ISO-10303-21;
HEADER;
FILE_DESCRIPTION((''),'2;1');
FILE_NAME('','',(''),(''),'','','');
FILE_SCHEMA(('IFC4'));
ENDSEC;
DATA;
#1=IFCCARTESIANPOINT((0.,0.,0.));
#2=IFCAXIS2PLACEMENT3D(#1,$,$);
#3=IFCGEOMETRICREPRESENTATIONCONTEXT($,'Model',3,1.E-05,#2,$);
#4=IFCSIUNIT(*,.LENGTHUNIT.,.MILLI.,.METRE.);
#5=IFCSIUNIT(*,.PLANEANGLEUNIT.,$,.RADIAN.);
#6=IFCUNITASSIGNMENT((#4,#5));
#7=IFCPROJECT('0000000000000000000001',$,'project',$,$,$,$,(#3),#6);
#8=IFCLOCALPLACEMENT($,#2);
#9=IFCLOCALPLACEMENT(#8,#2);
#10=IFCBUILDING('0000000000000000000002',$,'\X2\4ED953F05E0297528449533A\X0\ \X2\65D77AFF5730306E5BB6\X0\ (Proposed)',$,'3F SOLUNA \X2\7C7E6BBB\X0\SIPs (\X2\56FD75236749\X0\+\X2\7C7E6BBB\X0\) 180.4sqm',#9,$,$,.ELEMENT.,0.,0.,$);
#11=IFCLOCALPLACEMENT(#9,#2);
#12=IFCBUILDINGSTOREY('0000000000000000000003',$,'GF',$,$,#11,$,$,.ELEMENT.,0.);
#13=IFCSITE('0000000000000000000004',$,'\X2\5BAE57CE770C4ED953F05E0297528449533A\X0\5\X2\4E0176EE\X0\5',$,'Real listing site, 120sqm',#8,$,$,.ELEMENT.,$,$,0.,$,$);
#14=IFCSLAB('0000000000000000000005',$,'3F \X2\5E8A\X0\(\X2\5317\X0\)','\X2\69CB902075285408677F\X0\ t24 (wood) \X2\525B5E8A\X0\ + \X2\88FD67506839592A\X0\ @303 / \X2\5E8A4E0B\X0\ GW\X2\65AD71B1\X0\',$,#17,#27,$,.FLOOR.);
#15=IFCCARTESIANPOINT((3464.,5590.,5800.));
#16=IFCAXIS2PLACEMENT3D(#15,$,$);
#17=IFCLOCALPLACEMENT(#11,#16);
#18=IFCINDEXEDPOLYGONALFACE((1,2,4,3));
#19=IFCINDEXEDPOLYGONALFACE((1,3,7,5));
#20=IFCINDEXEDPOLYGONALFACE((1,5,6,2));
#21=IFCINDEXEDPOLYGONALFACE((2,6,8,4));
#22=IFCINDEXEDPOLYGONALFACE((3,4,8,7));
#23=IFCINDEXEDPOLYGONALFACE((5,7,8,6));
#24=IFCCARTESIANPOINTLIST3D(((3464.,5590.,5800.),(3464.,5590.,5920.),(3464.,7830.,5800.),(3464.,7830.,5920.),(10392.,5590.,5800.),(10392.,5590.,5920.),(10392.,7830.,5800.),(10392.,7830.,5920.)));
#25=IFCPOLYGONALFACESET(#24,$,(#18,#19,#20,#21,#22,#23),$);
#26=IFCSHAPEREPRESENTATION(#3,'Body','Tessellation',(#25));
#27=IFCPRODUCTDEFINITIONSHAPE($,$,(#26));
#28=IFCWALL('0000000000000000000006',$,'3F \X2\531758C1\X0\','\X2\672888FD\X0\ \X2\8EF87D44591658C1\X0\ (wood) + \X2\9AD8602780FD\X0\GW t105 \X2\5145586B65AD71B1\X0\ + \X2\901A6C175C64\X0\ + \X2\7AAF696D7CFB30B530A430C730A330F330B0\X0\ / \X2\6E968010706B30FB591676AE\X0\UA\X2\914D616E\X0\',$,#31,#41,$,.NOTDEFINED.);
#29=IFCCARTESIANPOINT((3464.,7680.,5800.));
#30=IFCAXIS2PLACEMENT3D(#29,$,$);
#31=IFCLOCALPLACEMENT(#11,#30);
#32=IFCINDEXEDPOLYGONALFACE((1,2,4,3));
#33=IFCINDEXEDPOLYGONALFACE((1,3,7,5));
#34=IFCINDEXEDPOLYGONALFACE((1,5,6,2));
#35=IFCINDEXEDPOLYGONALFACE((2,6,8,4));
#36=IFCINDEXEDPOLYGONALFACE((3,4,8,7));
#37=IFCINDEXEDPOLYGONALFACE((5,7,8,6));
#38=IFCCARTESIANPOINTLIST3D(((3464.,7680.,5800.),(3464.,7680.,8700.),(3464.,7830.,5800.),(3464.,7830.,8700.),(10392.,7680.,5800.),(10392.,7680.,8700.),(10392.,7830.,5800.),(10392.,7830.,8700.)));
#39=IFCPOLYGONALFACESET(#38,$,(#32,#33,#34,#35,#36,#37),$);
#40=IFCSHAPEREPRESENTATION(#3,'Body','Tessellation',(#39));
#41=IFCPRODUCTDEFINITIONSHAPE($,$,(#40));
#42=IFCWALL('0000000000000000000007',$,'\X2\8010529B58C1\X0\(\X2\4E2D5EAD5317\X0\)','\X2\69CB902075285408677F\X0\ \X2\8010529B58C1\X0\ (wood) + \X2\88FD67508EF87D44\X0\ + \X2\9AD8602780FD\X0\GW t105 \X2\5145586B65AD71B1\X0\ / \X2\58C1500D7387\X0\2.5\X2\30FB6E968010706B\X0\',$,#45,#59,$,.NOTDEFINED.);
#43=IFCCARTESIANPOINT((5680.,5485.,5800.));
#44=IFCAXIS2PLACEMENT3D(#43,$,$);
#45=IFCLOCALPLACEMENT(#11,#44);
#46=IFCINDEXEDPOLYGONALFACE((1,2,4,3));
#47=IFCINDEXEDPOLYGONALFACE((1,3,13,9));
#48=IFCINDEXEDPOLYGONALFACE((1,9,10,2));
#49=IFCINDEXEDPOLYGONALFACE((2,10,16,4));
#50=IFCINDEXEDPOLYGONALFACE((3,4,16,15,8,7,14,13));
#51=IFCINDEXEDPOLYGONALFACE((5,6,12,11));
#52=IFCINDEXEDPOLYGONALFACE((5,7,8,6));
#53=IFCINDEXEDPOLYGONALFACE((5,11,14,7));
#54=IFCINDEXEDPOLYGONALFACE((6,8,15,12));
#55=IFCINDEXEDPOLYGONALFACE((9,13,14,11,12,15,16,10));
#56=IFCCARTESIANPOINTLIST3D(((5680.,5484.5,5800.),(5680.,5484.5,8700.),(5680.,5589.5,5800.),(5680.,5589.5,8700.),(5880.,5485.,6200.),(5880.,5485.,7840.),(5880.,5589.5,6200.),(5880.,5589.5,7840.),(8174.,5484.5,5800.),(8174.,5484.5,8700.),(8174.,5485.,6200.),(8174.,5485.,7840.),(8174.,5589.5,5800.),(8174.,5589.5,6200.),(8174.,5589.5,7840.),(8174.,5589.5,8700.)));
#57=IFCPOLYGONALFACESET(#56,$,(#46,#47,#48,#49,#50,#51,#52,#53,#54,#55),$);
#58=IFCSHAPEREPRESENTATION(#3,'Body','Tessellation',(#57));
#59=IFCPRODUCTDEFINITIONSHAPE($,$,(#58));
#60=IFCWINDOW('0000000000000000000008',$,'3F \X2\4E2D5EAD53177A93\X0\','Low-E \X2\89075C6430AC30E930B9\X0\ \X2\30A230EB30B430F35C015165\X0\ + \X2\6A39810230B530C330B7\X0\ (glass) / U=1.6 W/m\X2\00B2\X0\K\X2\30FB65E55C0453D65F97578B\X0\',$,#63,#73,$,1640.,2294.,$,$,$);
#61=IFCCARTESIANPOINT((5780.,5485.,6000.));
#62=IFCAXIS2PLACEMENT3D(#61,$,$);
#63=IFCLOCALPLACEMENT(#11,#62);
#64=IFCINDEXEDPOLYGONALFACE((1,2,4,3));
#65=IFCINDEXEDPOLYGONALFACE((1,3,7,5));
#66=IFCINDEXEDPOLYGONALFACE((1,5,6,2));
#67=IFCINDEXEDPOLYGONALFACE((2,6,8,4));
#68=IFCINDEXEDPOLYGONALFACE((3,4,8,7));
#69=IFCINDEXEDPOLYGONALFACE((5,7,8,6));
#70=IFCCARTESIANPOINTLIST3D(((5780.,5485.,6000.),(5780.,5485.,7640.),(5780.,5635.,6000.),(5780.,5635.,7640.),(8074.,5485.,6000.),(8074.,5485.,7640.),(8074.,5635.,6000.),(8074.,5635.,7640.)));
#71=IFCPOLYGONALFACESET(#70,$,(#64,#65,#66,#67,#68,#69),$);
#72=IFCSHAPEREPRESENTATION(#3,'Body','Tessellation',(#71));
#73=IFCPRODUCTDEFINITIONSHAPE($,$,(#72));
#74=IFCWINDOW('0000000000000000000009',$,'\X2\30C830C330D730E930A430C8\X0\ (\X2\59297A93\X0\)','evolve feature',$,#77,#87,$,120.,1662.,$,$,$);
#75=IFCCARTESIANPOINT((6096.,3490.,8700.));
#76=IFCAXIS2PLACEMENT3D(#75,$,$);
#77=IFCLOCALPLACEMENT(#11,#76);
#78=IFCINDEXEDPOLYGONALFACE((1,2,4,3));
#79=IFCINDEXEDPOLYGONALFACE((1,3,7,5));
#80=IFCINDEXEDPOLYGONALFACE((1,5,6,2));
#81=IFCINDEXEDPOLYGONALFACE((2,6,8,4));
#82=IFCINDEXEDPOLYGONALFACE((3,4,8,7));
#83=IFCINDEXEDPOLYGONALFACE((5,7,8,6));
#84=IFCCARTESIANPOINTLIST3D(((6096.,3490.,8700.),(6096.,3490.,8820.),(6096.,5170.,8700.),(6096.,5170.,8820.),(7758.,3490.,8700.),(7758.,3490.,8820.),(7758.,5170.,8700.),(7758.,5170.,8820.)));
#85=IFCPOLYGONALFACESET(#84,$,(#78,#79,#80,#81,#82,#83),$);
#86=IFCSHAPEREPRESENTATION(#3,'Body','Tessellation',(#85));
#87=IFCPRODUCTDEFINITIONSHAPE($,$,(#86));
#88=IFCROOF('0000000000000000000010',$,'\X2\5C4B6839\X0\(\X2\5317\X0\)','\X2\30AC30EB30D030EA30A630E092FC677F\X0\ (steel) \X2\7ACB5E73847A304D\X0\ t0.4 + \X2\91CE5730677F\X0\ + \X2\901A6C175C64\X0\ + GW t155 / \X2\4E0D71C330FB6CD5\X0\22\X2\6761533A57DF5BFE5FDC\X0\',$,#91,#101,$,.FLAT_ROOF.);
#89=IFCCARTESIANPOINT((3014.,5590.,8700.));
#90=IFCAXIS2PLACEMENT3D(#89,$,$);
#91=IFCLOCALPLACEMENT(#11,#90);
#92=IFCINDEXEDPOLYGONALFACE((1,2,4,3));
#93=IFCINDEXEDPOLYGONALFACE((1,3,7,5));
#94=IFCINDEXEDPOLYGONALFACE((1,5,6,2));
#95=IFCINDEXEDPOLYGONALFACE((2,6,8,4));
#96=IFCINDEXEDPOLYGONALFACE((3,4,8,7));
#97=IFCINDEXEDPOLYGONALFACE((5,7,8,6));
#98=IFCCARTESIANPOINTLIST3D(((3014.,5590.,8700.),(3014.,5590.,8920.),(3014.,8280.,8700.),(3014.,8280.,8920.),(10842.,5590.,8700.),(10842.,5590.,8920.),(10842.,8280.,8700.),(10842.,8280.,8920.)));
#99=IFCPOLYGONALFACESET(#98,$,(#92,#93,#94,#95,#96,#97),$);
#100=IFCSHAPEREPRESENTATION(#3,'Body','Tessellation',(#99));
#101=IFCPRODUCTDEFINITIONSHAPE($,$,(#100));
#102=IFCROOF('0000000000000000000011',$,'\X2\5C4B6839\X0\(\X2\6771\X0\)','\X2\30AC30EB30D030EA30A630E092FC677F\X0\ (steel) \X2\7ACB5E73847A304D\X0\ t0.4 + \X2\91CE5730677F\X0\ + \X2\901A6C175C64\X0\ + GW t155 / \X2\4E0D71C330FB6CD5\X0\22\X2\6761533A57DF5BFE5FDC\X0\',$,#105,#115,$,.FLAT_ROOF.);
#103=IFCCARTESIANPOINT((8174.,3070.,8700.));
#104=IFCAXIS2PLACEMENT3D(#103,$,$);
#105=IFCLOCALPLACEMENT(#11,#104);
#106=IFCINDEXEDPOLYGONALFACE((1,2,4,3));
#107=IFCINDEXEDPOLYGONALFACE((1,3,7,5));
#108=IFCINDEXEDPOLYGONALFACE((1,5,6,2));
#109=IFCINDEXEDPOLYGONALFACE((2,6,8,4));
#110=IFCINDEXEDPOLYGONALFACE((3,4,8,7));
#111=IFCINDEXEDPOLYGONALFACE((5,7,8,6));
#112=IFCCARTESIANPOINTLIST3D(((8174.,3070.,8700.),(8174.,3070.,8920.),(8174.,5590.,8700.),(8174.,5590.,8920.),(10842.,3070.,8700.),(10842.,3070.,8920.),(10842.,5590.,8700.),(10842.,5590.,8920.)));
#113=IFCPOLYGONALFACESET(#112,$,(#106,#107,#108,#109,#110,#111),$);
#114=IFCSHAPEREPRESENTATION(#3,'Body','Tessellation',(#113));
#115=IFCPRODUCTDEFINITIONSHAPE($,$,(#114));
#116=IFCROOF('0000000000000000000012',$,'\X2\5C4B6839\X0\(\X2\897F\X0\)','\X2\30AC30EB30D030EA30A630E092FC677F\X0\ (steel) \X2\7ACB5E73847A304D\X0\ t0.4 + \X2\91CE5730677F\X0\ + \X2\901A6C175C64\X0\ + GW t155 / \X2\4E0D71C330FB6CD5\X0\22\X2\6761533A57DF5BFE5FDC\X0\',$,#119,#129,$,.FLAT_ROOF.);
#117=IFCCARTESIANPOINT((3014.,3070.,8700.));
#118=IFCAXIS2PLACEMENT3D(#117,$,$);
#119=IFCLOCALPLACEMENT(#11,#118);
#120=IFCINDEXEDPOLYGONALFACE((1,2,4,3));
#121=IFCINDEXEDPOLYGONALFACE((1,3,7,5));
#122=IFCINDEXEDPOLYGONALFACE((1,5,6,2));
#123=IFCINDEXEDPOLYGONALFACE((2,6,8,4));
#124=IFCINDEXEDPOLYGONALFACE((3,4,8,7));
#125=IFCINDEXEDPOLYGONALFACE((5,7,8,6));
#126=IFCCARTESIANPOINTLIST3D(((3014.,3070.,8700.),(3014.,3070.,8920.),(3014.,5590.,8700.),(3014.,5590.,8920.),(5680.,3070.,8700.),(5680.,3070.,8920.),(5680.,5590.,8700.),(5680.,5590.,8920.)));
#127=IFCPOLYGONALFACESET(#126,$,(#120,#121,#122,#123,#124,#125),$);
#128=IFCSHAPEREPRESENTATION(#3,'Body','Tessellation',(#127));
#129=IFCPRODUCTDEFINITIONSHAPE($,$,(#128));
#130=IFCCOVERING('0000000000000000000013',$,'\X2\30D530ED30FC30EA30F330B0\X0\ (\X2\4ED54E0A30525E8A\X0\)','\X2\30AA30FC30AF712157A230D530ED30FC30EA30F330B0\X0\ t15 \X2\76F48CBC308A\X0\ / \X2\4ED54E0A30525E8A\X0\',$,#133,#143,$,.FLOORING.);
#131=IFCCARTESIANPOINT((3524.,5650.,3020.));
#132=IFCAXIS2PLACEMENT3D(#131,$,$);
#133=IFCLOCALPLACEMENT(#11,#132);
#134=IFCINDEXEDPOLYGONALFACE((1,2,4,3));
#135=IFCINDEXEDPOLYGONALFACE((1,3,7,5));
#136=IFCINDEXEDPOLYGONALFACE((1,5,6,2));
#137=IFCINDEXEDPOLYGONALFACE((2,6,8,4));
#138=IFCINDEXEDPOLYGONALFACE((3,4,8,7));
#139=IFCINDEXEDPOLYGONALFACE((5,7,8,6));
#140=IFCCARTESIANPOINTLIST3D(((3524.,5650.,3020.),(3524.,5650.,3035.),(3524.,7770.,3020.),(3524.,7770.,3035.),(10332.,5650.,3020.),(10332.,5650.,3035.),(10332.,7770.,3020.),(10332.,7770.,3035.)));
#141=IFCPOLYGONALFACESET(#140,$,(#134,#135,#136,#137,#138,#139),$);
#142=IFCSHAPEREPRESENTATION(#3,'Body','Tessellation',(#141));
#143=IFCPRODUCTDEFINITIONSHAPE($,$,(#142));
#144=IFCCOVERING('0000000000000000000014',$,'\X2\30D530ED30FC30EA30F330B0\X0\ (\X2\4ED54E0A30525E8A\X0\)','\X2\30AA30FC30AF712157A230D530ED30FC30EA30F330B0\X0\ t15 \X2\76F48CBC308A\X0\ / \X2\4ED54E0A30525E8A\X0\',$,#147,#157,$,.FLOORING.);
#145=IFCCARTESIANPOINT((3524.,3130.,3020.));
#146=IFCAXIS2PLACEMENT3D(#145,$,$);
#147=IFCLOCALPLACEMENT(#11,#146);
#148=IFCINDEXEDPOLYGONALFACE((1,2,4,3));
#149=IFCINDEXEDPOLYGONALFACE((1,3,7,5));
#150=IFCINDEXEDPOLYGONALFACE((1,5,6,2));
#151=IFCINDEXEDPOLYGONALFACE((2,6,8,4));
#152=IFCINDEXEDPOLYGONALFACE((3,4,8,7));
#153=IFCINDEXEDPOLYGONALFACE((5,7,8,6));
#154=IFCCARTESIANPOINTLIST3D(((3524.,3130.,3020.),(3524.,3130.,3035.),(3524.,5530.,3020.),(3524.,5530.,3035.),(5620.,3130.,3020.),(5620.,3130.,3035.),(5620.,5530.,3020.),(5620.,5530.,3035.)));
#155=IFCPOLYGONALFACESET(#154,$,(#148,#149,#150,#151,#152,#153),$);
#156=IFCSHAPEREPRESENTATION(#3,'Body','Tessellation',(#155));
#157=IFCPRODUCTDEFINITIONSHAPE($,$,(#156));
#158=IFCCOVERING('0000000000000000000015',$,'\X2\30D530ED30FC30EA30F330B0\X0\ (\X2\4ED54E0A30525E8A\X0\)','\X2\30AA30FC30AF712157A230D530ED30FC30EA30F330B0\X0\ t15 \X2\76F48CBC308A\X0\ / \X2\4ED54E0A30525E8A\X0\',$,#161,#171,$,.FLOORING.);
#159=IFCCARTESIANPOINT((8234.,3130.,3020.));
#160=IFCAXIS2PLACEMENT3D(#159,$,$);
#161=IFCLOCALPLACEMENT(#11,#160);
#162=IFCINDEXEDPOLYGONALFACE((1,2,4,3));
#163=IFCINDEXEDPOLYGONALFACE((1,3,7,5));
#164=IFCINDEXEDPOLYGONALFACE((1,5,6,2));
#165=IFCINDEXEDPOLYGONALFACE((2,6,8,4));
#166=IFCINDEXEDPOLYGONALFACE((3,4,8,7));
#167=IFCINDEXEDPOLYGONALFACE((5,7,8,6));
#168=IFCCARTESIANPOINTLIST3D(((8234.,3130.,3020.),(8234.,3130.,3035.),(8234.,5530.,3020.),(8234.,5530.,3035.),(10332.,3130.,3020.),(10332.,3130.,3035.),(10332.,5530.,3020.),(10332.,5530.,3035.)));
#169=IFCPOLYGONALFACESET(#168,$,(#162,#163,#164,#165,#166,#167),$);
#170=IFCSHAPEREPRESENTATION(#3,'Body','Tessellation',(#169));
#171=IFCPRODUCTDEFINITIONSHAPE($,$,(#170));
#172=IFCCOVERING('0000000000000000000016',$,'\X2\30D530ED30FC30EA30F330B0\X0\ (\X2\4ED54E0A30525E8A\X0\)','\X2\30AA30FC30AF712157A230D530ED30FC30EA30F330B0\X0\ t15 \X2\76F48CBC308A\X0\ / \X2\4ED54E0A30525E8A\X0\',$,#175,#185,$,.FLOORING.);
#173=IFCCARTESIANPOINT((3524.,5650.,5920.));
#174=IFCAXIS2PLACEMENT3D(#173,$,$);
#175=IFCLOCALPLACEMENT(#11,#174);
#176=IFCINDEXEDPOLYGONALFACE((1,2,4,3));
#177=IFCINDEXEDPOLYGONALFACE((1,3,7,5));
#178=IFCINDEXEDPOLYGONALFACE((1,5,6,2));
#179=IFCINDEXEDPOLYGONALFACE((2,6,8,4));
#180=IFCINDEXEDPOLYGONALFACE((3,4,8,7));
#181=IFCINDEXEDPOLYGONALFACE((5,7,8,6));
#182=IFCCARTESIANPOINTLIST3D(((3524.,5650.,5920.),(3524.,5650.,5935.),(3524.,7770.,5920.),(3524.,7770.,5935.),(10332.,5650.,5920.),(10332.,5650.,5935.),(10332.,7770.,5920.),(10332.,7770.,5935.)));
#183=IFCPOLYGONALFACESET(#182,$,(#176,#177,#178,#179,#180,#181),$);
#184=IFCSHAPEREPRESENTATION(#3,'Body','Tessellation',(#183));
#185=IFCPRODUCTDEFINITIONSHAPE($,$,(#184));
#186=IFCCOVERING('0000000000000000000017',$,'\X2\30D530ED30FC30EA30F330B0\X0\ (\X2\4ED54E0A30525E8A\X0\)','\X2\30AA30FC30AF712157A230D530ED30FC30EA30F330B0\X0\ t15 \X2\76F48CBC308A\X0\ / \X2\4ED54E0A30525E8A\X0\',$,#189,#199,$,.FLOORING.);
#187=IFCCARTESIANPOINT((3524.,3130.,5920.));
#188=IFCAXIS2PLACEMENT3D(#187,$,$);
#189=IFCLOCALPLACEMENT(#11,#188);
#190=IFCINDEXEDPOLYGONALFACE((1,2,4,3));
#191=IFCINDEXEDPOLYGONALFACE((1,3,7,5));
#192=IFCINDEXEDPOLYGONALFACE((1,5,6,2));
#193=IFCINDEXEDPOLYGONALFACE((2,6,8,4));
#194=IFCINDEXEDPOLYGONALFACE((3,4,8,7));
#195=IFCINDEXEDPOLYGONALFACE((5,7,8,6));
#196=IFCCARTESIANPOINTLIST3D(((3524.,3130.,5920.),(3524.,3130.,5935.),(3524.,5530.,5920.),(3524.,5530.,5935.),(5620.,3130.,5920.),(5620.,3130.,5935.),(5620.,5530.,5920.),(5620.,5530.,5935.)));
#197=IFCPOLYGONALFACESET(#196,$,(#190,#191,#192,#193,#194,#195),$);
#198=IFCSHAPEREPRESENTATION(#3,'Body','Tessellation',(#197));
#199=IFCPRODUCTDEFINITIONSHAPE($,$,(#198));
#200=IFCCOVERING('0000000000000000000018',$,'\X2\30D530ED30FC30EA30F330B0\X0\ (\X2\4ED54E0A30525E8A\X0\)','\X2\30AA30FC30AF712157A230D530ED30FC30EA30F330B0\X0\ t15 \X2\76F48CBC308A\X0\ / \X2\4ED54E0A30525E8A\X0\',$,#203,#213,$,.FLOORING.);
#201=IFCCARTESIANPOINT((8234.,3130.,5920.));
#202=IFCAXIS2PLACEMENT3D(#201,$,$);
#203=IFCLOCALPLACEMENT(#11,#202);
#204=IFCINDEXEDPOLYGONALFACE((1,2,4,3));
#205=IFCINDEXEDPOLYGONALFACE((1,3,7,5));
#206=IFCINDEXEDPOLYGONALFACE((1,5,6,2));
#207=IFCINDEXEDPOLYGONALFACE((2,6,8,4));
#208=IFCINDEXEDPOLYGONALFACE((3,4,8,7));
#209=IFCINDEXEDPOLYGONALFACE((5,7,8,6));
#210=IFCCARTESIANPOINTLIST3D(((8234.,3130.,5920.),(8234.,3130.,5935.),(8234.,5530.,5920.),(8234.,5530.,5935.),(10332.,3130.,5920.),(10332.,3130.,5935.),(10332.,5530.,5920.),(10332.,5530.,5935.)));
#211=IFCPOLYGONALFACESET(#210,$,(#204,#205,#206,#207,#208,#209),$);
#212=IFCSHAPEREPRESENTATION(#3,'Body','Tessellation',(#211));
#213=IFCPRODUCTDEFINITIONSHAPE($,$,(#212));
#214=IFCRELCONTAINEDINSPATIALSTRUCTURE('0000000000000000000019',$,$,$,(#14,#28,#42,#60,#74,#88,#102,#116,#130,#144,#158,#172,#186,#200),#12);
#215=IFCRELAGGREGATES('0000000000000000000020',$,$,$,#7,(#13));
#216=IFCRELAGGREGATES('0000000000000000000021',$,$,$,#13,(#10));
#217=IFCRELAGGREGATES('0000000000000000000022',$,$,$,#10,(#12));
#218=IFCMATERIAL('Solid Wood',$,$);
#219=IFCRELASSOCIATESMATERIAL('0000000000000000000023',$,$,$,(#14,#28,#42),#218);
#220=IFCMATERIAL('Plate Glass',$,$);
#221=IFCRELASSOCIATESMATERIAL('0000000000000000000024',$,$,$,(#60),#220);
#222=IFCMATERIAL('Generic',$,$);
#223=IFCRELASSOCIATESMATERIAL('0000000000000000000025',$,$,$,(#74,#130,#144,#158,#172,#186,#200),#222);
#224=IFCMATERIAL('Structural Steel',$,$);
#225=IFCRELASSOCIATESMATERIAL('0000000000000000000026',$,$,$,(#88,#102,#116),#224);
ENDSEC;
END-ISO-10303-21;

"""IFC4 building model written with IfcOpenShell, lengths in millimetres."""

from ifc_helpers import new_model, si_unit, frame, frame_2d, origin, place, context, project, spatial, rectangle, extrude, material, element, fill, save


model = new_model("IFC4")

# Units and contexts
model_context = context("Model", 3, precision=1e-05, world=origin())
ifc_project = project(units=[si_unit("LENGTHUNIT", "METRE", prefix="MILLI"), si_unit("PLANEANGLEUNIT", "RADIAN")], contexts=[model_context])

# Site, building, storey
site_placement = place(None, origin())
site = spatial("IfcSite", under=ifc_project, at=site_placement, Name="宮城県仙台市青葉区5丁目5", ObjectType="Real listing site, 120sqm", CompositionType="ELEMENT", RefElevation=0.0)
building_placement = place(site_placement, origin())
building = spatial("IfcBuilding", under=site, at=building_placement, Name="仙台市青葉区 旗竿地の家 (Proposed)", ObjectType="3F SOLUNA 籾殻SIPs (国産杉+籾殻) 180.4sqm", CompositionType="ELEMENT", ElevationOfRefHeight=0.0, ElevationOfTerrain=0.0)
storey_placement = place(building_placement, origin())
storey = spatial("IfcBuildingStorey", under=building, at=storey_placement, Name="GF", CompositionType="ELEMENT", Elevation=0.0)

# Slab
ifc_material_1 = material(Name="Solid Wood")
slab_placement = place(storey_placement, frame((3464.0, 5590.0, 5800.0)))
element("IfcSlab", 1, at=slab_placement, inside=storey, material=ifc_material_1, Name="3F 床(北)", Description="構造用合板 t24 (wood) 剛床 + 製材根太 @303 / 床下 GW断熱", PredefinedType="FLOOR", context=model_context, shape_type="SweptSolid", body=[
    extrude(rectangle(XDim=6928.0, YDim=2240.0, at=frame_2d((3464.0, 1120.0))), frame((3464.0, 5590.0, 5800.0)), (0.0, 0.0, 1.0), 120.0),
])

# Wall
wall_1_placement = place(storey_placement, frame((3464.0, 7680.0, 5800.0)))
element("IfcWall", 2, at=wall_1_placement, inside=storey, material=ifc_material_1, Name="3F 北壁", Description="木製 軸組外壁 (wood) + 高性能GW t105 充填断熱 + 通気層 + 窯業系サイディング / 準耐火・外皮UA配慮", PredefinedType="NOTDEFINED", context=model_context, shape_type="SweptSolid", body=[
    extrude(rectangle(XDim=6928.0, YDim=150.0, at=frame_2d((3464.0, 75.0))), frame((3464.0, 7680.0, 5800.0)), (0.0, 0.0, 1.0), 2900.0),
])

# Wall, opening, window
wall_2_placement = place(storey_placement, frame((5680.0, 5485.0, 5800.0)))
wall_2 = element("IfcWall", 3, at=wall_2_placement, inside=storey, material=ifc_material_1, Name="耐力壁(中庭北)", Description="構造用合板 耐力壁 (wood) + 製材軸組 + 高性能GW t105 充填断熱 / 壁倍率2.5・準耐火", PredefinedType="NOTDEFINED", context=model_context, shape_type="SweptSolid", body=[
    extrude(rectangle(XDim=2494.0, YDim=105.0, at=frame_2d((1247.0, 52.0))), frame((5680.0, 5485.0, 5800.0)), (0.0, 0.0, 1.0), 2900.0),
])
opening_placement = place(storey_placement, frame((5780.0, 5485.0, 6000.0)))
opening = element("IfcOpeningElement", 4, at=opening_placement, cuts=wall_2, PredefinedType="NOTDEFINED", context=model_context, shape_type="SweptSolid", body=[
    extrude(rectangle(XDim=2294.0, YDim=150.0, at=frame_2d((1147.0, 75.0))), frame((5780.0, 5485.0, 6000.0)), (0.0, 0.0, 1.0), 1640.0),
])
ifc_material_2 = material(Name="Plate Glass")
window_1_placement = place(storey_placement, frame((5780.0, 5485.0, 6000.0)))
window_1 = element("IfcWindow", 5, at=window_1_placement, inside=storey, material=ifc_material_2, Name="3F 中庭北窓", Description="Low-E 複層ガラス アルゴン封入 + 樹脂サッシ (glass) / U=1.6 W/m²K・日射取得型", OverallHeight=1640.0, OverallWidth=2294.0, context=model_context, shape_type="SweptSolid", body=[
    extrude(rectangle(XDim=2294.0, YDim=150.0, at=frame_2d((1147.0, 75.0))), frame((5780.0, 5485.0, 6000.0)), (0.0, 0.0, 1.0), 1640.0),
])
fill(opening, window_1)

# Window
ifc_material_3 = material(Name="Generic")
window_2_placement = place(storey_placement, frame((6096.0, 3490.0, 8700.0)))
element("IfcWindow", 6, at=window_2_placement, inside=storey, material=ifc_material_3, Name="トップライト (天窓)", Description="evolve feature", OverallHeight=120.0, OverallWidth=1662.0, context=model_context, shape_type="SweptSolid", body=[
    extrude(rectangle(XDim=1662.0, YDim=1680.0, at=frame_2d((831.0, 840.0))), frame((6096.0, 3490.0, 8700.0)), (0.0, 0.0, 1.0), 120.0),
])

# Roofs
ifc_material_4 = material(Name="Structural Steel")
roof_1_placement = place(storey_placement, frame((3014.0, 5590.0, 8700.0)))
element("IfcRoof", 7, at=roof_1_placement, inside=storey, material=ifc_material_4, Name="屋根(北)", Description="ガルバリウム鋼板 (steel) 立平葺き t0.4 + 野地板 + 通気層 + GW t155 / 不燃・法22条区域対応", PredefinedType="FLAT_ROOF", context=model_context, shape_type="SweptSolid", body=[
    extrude(rectangle(XDim=7828.0, YDim=2690.0, at=frame_2d((3914.0, 1345.0))), frame((3014.0, 5590.0, 8700.0)), (0.0, 0.0, 1.0), 220.0),
])
roof_2_placement = place(storey_placement, frame((8174.0, 3070.0, 8700.0)))
element("IfcRoof", 8, at=roof_2_placement, inside=storey, material=ifc_material_4, Name="屋根(東)", Description="ガルバリウム鋼板 (steel) 立平葺き t0.4 + 野地板 + 通気層 + GW t155 / 不燃・法22条区域対応", PredefinedType="FLAT_ROOF", context=model_context, shape_type="SweptSolid", body=[
    extrude(rectangle(XDim=2668.0, YDim=2520.0, at=frame_2d((1334.0, 1260.0))), frame((8174.0, 3070.0, 8700.0)), (0.0, 0.0, 1.0), 220.0),
])
roof_3_placement = place(storey_placement, frame((3014.0, 3070.0, 8700.0)))
element("IfcRoof", 9, at=roof_3_placement, inside=storey, material=ifc_material_4, Name="屋根(西)", Description="ガルバリウム鋼板 (steel) 立平葺き t0.4 + 野地板 + 通気層 + GW t155 / 不燃・法22条区域対応", PredefinedType="FLAT_ROOF", context=model_context, shape_type="SweptSolid", body=[
    extrude(rectangle(XDim=2666.0, YDim=2520.0, at=frame_2d((1333.0, 1260.0))), frame((3014.0, 3070.0, 8700.0)), (0.0, 0.0, 1.0), 220.0),
])

# Coverings
covering_1_placement = place(storey_placement, frame((3524.0, 5650.0, 3020.0)))
element("IfcCovering", 10, at=covering_1_placement, inside=storey, material=ifc_material_3, Name="フローリング (仕上げ床)", Description="オーク無垢フローリング t15 直貼り / 仕上げ床", PredefinedType="FLOORING", context=model_context, shape_type="SweptSolid", body=[
    extrude(rectangle(XDim=6808.0, YDim=2120.0, at=frame_2d((3404.0, 1060.0))), frame((3524.0, 5650.0, 3020.0)), (0.0, 0.0, 1.0), 15.0),
])
covering_2_placement = place(storey_placement, frame((3524.0, 3130.0, 3020.0)))
element("IfcCovering", 11, at=covering_2_placement, inside=storey, material=ifc_material_3, Name="フローリング (仕上げ床)", Description="オーク無垢フローリング t15 直貼り / 仕上げ床", PredefinedType="FLOORING", context=model_context, shape_type="SweptSolid", body=[
    extrude(rectangle(XDim=2096.0, YDim=2400.0, at=frame_2d((1048.0, 1200.0))), frame((3524.0, 3130.0, 3020.0)), (0.0, 0.0, 1.0), 15.0),
])
covering_3_placement = place(storey_placement, frame((8234.0, 3130.0, 3020.0)))
element("IfcCovering", 12, at=covering_3_placement, inside=storey, material=ifc_material_3, Name="フローリング (仕上げ床)", Description="オーク無垢フローリング t15 直貼り / 仕上げ床", PredefinedType="FLOORING", context=model_context, shape_type="SweptSolid", body=[
    extrude(rectangle(XDim=2098.0, YDim=2400.0, at=frame_2d((1049.0, 1200.0))), frame((8234.0, 3130.0, 3020.0)), (0.0, 0.0, 1.0), 15.0),
])
covering_4_placement = place(storey_placement, frame((3524.0, 5650.0, 5920.0)))
element("IfcCovering", 13, at=covering_4_placement, inside=storey, material=ifc_material_3, Name="フローリング (仕上げ床)", Description="オーク無垢フローリング t15 直貼り / 仕上げ床", PredefinedType="FLOORING", context=model_context, shape_type="SweptSolid", body=[
    extrude(rectangle(XDim=6808.0, YDim=2120.0, at=frame_2d((3404.0, 1060.0))), frame((3524.0, 5650.0, 5920.0)), (0.0, 0.0, 1.0), 15.0),
])
covering_5_placement = place(storey_placement, frame((3524.0, 3130.0, 5920.0)))
element("IfcCovering", 14, at=covering_5_placement, inside=storey, material=ifc_material_3, Name="フローリング (仕上げ床)", Description="オーク無垢フローリング t15 直貼り / 仕上げ床", PredefinedType="FLOORING", context=model_context, shape_type="SweptSolid", body=[
    extrude(rectangle(XDim=2096.0, YDim=2400.0, at=frame_2d((1048.0, 1200.0))), frame((3524.0, 3130.0, 5920.0)), (0.0, 0.0, 1.0), 15.0),
])
covering_6_placement = place(storey_placement, frame((8234.0, 3130.0, 5920.0)))
element("IfcCovering", 15, at=covering_6_placement, inside=storey, material=ifc_material_3, Name="フローリング (仕上げ床)", Description="オーク無垢フローリング t15 直貼り / 仕上げ床", PredefinedType="FLOORING", context=model_context, shape_type="SweptSolid", body=[
    extrude(rectangle(XDim=2098.0, YDim=2400.0, at=frame_2d((1049.0, 1200.0))), frame((8234.0, 3130.0, 5920.0)), (0.0, 0.0, 1.0), 15.0),
])

save(model, "model.ifc")
